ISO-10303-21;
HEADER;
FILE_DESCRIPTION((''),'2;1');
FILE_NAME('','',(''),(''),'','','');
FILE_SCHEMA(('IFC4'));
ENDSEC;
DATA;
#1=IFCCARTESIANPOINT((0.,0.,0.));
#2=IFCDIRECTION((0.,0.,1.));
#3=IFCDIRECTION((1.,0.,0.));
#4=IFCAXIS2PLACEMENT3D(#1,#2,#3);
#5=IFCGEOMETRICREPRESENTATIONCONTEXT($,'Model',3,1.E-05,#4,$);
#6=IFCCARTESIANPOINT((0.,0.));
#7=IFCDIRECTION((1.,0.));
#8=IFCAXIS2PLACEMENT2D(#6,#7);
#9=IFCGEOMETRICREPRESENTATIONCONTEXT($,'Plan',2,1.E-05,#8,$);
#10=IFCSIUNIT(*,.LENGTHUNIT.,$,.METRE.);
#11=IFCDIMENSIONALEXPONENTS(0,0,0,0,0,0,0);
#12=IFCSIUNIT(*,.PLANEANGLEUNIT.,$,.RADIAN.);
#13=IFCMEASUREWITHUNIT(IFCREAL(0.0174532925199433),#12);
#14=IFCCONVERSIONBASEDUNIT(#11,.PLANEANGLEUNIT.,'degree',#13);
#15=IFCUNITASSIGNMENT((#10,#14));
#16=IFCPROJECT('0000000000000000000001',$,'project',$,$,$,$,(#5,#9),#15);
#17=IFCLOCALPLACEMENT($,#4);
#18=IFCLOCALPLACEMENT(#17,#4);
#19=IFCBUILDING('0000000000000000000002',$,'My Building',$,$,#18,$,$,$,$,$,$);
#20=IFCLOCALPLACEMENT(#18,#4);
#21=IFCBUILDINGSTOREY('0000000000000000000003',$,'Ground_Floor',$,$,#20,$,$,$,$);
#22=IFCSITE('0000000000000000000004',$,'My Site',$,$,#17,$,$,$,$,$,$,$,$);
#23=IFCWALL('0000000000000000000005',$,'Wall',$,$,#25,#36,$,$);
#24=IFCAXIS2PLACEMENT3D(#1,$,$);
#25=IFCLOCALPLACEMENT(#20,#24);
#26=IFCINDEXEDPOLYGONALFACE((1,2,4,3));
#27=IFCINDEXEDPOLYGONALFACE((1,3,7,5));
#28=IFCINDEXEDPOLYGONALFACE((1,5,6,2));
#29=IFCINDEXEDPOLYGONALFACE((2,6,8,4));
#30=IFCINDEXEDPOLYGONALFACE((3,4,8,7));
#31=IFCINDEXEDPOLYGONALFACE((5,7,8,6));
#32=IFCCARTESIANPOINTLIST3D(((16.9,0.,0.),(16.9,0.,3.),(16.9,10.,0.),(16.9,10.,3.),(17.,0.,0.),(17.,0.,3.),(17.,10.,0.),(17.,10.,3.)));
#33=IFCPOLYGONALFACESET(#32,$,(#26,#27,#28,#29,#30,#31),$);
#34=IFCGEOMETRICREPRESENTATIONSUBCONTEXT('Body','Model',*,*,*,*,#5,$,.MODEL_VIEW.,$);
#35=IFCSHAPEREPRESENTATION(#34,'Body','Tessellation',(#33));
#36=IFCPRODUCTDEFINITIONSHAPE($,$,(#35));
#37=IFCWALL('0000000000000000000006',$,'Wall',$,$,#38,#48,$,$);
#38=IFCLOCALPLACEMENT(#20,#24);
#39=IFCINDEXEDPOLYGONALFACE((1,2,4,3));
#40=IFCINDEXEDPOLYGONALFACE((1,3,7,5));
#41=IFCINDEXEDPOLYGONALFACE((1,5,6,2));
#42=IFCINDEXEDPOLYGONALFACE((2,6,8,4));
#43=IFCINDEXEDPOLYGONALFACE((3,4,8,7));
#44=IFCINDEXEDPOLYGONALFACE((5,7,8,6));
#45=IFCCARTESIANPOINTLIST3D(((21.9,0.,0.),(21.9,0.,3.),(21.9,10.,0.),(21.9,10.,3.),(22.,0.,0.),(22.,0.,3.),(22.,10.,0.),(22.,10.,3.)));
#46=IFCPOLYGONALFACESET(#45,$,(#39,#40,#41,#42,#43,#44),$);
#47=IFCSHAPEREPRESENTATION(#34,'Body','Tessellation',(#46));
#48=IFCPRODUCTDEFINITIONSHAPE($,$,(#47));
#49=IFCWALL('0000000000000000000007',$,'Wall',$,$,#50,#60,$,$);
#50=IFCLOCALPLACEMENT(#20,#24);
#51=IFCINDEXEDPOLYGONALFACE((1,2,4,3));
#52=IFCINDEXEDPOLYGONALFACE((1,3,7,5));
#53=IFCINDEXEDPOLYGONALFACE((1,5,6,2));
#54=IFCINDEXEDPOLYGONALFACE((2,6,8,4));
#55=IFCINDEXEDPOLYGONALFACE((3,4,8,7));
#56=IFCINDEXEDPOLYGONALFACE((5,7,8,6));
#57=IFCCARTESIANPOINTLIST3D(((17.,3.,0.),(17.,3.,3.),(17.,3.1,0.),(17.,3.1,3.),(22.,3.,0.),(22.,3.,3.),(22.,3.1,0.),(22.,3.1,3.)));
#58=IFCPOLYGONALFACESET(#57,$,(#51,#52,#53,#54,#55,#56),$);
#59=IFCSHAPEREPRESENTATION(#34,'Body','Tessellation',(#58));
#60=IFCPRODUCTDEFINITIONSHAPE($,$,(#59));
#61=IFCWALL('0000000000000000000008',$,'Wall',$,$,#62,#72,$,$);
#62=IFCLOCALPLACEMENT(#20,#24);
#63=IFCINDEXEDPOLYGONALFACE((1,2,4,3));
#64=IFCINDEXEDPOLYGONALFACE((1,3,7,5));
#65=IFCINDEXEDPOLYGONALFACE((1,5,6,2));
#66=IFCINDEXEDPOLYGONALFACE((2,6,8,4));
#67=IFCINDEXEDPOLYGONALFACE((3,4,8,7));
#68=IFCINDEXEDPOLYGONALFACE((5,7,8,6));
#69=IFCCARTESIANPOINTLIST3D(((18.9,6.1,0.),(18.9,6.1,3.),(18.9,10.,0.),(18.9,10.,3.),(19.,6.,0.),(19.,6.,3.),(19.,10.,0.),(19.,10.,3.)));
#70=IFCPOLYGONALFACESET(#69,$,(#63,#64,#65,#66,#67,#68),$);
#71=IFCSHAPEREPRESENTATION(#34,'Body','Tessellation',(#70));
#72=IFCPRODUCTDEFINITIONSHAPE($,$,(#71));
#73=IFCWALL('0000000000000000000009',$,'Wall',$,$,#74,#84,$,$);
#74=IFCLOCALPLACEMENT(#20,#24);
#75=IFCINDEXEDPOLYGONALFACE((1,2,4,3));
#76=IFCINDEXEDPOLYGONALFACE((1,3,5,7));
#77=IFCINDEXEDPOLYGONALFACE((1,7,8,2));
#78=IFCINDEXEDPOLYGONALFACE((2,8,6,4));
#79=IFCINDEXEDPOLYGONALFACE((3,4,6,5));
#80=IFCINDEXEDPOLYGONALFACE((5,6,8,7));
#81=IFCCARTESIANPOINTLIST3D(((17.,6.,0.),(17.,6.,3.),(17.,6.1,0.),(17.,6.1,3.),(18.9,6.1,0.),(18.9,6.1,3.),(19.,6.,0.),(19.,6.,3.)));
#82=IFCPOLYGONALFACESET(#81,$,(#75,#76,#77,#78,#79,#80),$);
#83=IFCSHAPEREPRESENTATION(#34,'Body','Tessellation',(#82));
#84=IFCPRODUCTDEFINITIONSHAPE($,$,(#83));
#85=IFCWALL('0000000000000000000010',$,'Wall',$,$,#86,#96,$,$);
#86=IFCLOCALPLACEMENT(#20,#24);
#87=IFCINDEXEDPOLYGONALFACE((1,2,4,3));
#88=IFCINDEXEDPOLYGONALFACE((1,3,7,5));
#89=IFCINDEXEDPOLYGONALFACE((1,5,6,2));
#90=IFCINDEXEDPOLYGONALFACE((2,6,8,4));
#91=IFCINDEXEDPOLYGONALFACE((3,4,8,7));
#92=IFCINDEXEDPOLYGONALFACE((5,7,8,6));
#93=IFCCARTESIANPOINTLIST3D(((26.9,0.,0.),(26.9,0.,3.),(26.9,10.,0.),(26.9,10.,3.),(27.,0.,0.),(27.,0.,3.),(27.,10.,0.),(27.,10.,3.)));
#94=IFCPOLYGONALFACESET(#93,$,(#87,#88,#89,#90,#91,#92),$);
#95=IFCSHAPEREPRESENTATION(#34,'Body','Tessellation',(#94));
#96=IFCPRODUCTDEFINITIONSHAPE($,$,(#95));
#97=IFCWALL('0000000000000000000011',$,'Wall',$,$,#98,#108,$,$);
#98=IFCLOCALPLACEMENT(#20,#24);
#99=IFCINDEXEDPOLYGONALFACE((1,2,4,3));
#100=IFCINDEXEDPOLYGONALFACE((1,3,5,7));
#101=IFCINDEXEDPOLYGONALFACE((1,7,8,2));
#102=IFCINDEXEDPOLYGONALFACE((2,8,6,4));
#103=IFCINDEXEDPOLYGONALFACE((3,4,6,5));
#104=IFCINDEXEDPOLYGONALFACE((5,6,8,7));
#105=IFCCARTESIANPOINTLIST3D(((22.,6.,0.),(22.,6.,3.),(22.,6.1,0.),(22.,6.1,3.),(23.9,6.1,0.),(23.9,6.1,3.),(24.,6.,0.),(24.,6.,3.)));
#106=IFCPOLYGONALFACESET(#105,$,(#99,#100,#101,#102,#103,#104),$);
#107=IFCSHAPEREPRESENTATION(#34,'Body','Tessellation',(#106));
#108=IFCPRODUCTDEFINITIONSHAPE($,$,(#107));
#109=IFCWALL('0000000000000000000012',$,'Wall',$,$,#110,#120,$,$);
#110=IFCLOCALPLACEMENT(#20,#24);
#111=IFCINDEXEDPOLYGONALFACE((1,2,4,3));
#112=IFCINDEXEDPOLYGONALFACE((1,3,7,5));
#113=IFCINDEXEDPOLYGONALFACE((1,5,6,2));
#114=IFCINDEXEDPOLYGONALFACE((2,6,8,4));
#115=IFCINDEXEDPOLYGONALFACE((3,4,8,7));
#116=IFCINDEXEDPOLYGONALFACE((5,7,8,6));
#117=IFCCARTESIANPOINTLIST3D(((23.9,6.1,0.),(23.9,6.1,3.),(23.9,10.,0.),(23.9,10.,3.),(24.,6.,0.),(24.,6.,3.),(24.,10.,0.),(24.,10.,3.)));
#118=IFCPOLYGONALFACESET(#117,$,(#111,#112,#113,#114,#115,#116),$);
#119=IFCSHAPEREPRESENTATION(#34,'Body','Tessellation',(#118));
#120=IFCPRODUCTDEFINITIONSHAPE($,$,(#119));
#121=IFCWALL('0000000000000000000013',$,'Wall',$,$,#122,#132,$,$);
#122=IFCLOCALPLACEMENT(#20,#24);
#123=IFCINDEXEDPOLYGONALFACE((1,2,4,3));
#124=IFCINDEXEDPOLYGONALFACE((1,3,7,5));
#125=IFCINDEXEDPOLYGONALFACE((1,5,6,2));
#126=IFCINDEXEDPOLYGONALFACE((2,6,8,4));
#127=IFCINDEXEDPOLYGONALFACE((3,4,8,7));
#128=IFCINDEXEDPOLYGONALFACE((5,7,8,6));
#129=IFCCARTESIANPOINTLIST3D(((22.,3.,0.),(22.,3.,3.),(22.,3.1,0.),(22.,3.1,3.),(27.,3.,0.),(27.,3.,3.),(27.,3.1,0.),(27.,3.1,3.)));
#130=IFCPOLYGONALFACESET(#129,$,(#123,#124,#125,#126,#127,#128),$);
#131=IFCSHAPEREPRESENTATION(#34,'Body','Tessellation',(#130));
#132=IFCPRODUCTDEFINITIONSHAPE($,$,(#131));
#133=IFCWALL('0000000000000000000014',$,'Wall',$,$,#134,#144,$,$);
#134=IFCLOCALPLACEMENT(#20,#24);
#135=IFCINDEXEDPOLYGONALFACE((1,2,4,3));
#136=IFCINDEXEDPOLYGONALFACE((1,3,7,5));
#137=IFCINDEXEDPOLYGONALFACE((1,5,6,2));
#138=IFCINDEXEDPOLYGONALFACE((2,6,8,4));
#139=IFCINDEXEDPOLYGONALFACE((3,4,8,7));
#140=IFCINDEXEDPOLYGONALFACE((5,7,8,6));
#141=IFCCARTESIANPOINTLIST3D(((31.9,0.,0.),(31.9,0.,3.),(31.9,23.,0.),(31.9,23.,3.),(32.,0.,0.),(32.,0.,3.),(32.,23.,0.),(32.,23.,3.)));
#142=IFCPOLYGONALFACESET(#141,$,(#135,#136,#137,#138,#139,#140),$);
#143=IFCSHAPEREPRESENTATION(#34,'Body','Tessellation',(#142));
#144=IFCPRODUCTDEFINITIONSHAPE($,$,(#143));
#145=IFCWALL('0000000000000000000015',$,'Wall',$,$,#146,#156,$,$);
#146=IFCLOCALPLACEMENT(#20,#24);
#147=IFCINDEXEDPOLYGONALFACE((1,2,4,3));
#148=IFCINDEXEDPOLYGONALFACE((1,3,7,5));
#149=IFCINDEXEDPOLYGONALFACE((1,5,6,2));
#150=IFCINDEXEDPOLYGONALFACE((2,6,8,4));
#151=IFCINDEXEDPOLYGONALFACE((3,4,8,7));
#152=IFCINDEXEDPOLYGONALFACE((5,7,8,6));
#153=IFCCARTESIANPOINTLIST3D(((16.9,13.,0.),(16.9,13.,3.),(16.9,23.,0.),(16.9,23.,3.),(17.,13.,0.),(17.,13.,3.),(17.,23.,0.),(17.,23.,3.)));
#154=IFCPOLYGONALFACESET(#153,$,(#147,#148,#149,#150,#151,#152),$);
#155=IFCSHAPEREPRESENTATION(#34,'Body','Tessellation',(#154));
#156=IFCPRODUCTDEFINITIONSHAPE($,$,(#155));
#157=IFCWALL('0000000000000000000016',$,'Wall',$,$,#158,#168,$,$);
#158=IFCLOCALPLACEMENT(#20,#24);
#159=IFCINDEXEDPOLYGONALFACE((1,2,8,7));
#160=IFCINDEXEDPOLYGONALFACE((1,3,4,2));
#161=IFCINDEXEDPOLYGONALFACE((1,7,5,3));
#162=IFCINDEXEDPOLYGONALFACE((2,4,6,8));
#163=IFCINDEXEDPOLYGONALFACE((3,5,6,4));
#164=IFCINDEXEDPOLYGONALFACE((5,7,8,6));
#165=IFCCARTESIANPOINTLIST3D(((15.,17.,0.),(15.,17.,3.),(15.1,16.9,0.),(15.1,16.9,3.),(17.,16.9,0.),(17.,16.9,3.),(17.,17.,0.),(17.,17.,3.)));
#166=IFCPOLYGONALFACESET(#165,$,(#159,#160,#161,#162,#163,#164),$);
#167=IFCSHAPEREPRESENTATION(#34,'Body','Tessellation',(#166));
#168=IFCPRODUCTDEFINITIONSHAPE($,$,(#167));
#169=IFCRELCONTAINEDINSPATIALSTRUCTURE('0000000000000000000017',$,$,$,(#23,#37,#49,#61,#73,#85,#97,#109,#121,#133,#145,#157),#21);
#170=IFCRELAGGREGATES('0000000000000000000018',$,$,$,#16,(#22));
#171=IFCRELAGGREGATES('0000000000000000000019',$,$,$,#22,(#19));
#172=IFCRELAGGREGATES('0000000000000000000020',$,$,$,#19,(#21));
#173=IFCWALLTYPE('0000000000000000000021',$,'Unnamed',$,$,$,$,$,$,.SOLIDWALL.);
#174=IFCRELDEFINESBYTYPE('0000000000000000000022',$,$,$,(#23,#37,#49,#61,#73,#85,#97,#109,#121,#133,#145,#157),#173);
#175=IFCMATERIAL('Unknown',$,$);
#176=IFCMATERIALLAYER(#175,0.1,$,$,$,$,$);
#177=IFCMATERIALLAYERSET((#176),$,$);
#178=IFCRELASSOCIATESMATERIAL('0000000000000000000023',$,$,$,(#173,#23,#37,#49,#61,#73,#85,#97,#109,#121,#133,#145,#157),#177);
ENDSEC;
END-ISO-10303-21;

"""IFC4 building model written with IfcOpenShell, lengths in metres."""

from ifc_helpers import new_model, entity, si_unit, converted_unit, frame, origin_with_axes, origin_2d_with_axis, place, context, subcontext, project, spatial, line, indexed_curve, outline, extrude, material, layer, layer_set, layer_usage, type_object, element, save


model = new_model("IFC4")

# Units and contexts
model_context = context("Model", 3, precision=1e-05, world=origin_with_axes())
plan_context = context("Plan", 2, precision=1e-05, world=origin_2d_with_axis())
body_context_1 = subcontext(model_context, "Body", "Model", "MODEL_VIEW")
ifc_project = project(units=[si_unit("LENGTHUNIT", "METRE"), converted_unit("PLANEANGLEUNIT", "degree", entity("IfcReal", 0.0174532925199433), si_unit("PLANEANGLEUNIT", "RADIAN"), dimensions=[0, 0, 0, 0, 0, 0, 0])], contexts=[model_context, plan_context])

# Site, building, storey
site_placement = place(None, origin_with_axes())
site = spatial("IfcSite", under=ifc_project, at=site_placement, Name="My Site")
building_placement = place(site_placement, origin_with_axes())
building = spatial("IfcBuilding", under=site, at=building_placement, Name="My Building")
storey_placement = place(building_placement, origin_with_axes())
storey = spatial("IfcBuildingStorey", under=building, at=storey_placement, Name="Ground_Floor")

# Walls
ifc_material = material(Name="Unknown")
ifc_layer = layer(ifc_material, 0.1)
ifc_layer_set = layer_set([ifc_layer])
ifc_layer_usage_1 = layer_usage(ifc_layer_set, "AXIS2", "POSITIVE", 0.0)
wall_type = type_object("IfcWallType", Name="Unnamed", PredefinedType="SOLIDWALL", material=ifc_layer_set)
wall_1_placement = place(storey_placement, frame((17.0, 0.0, 0.0), z_axis=(0.0, 0.0, 1.0), x_axis=(0.0, 1.0, 0.0)))
element("IfcWall", 1, at=wall_1_placement, inside=storey, type_object=wall_type, material=ifc_layer_usage_1, Name="Wall", context=body_context_1, shape_type="SweptSolid", body=[
    extrude(outline(indexed_curve([(0.0, 0.0), (0.0, 0.1), (10.0, 0.1), (10.0, 0.0)], segments=[line(1, 2, 3, 4, 1)])), origin_with_axes(), (0.0, 0.0, 1.0), 3.0),
])
ifc_layer_usage_2 = layer_usage(ifc_layer_set, "AXIS2", "POSITIVE", 0.0)
wall_2_placement = place(storey_placement, frame((22.0, 0.0, 0.0), z_axis=(0.0, 0.0, 1.0), x_axis=(0.0, 1.0, 0.0)))
element("IfcWall", 2, at=wall_2_placement, inside=storey, type_object=wall_type, material=ifc_layer_usage_2, Name="Wall", context=body_context_1, shape_type="SweptSolid", body=[
    extrude(outline(indexed_curve([(0.0, 0.0), (0.0, 0.1), (10.0, 0.1), (10.0, 0.0)], segments=[line(1, 2, 3, 4, 1)])), origin_with_axes(), (0.0, 0.0, 1.0), 3.0),
])
ifc_layer_usage_3 = layer_usage(ifc_layer_set, "AXIS2", "POSITIVE", 0.0)
wall_3_placement = place(storey_placement, frame((17.0, 3.0, 0.0), z_axis=(0.0, 0.0, 1.0), x_axis=(1.0, 0.0, 0.0)))
element("IfcWall", 3, at=wall_3_placement, inside=storey, type_object=wall_type, material=ifc_layer_usage_3, Name="Wall", context=body_context_1, shape_type="SweptSolid", body=[
    extrude(outline(indexed_curve([(0.0, 0.0), (0.0, 0.1), (5.0, 0.1), (5.0, 0.0)], segments=[line(1, 2, 3, 4, 1)])), origin_with_axes(), (0.0, 0.0, 1.0), 3.0),
])
ifc_layer_usage_4 = layer_usage(ifc_layer_set, "AXIS2", "POSITIVE", 0.0)
wall_4_placement = place(storey_placement, frame((19.0, 6.0, 0.0), z_axis=(0.0, 0.0, 1.0), x_axis=(0.0, 1.0, 0.0)))
element("IfcWall", 4, at=wall_4_placement, inside=storey, type_object=wall_type, material=ifc_layer_usage_4, Name="Wall", context=body_context_1, shape_type="SweptSolid", body=[
    extrude(outline(indexed_curve([(0.0, 0.0), (0.1, 0.1), (4.0, 0.1), (4.0, 0.0)], segments=[line(1, 2, 3, 4, 1)])), origin_with_axes(), (0.0, 0.0, 1.0), 3.0),
])
ifc_layer_usage_5 = layer_usage(ifc_layer_set, "AXIS2", "POSITIVE", 0.0)
wall_5_placement = place(storey_placement, frame((17.0, 6.0, 0.0), z_axis=(0.0, 0.0, 1.0), x_axis=(1.0, 0.0, 0.0)))
element("IfcWall", 5, at=wall_5_placement, inside=storey, type_object=wall_type, material=ifc_layer_usage_5, Name="Wall", context=body_context_1, shape_type="SweptSolid", body=[
    extrude(outline(indexed_curve([(0.0, 0.0), (0.0, 0.1), (1.9, 0.1), (2.0, 0.0)], segments=[line(1, 2, 3, 4, 1)])), origin_with_axes(), (0.0, 0.0, 1.0), 3.0),
])
ifc_layer_usage_6 = layer_usage(ifc_layer_set, "AXIS2", "POSITIVE", 0.0)
wall_6_placement = place(storey_placement, frame((27.0, 0.0, 0.0), z_axis=(0.0, 0.0, 1.0), x_axis=(0.0, 1.0, 0.0)))
element("IfcWall", 6, at=wall_6_placement, inside=storey, type_object=wall_type, material=ifc_layer_usage_6, Name="Wall", context=body_context_1, shape_type="SweptSolid", body=[
    extrude(outline(indexed_curve([(0.0, 0.0), (0.0, 0.1), (10.0, 0.1), (10.0, 0.0)], segments=[line(1, 2, 3, 4, 1)])), origin_with_axes(), (0.0, 0.0, 1.0), 3.0),
])
ifc_layer_usage_7 = layer_usage(ifc_layer_set, "AXIS2", "POSITIVE", 0.0)
wall_7_placement = place(storey_placement, frame((22.0, 6.0, 0.0), z_axis=(0.0, 0.0, 1.0), x_axis=(1.0, 0.0, 0.0)))
element("IfcWall", 7, at=wall_7_placement, inside=storey, type_object=wall_type, material=ifc_layer_usage_7, Name="Wall", context=body_context_1, shape_type="SweptSolid", body=[
    extrude(outline(indexed_curve([(0.0, 0.0), (0.0, 0.1), (1.9, 0.1), (2.0, 0.0)], segments=[line(1, 2, 3, 4, 1)])), origin_with_axes(), (0.0, 0.0, 1.0), 3.0),
])
ifc_layer_usage_8 = layer_usage(ifc_layer_set, "AXIS2", "POSITIVE", 0.0)
wall_8_placement = place(storey_placement, frame((24.0, 6.0, 0.0), z_axis=(0.0, 0.0, 1.0), x_axis=(0.0, 1.0, 0.0)))
element("IfcWall", 8, at=wall_8_placement, inside=storey, type_object=wall_type, material=ifc_layer_usage_8, Name="Wall", context=body_context_1, shape_type="SweptSolid", body=[
    extrude(outline(indexed_curve([(0.0, 0.0), (0.1, 0.1), (4.0, 0.1), (4.0, 0.0)], segments=[line(1, 2, 3, 4, 1)])), origin_with_axes(), (0.0, 0.0, 1.0), 3.0),
])
ifc_layer_usage_9 = layer_usage(ifc_layer_set, "AXIS2", "POSITIVE", 0.0)
wall_9_placement = place(storey_placement, frame((22.0, 3.0, 0.0), z_axis=(0.0, 0.0, 1.0), x_axis=(1.0, 0.0, 0.0)))
element("IfcWall", 9, at=wall_9_placement, inside=storey, type_object=wall_type, material=ifc_layer_usage_9, Name="Wall", context=body_context_1, shape_type="SweptSolid", body=[
    extrude(outline(indexed_curve([(0.0, 0.0), (0.0, 0.1), (5.0, 0.1), (5.0, 0.0)], segments=[line(1, 2, 3, 4, 1)])), origin_with_axes(), (0.0, 0.0, 1.0), 3.0),
])
ifc_layer_usage_10 = layer_usage(ifc_layer_set, "AXIS2", "POSITIVE", 0.0)
wall_10_placement = place(storey_placement, frame((32.0, 0.0, 0.0), z_axis=(0.0, 0.0, 1.0), x_axis=(0.0, 1.0, 0.0)))
element("IfcWall", 10, at=wall_10_placement, inside=storey, type_object=wall_type, material=ifc_layer_usage_10, Name="Wall", context=body_context_1, shape_type="SweptSolid", body=[
    extrude(outline(indexed_curve([(0.0, 0.0), (0.0, 0.1), (23.0, 0.1), (23.0, 0.0)], segments=[line(1, 2, 3, 4, 1)])), origin_with_axes(), (0.0, 0.0, 1.0), 3.0),
])
ifc_layer_usage_11 = layer_usage(ifc_layer_set, "AXIS2", "POSITIVE", 0.0)
wall_11_placement = place(storey_placement, frame((17.0, 13.0, 0.0), z_axis=(0.0, 0.0, 1.0), x_axis=(0.0, 1.0, 0.0)))
element("IfcWall", 11, at=wall_11_placement, inside=storey, type_object=wall_type, material=ifc_layer_usage_11, Name="Wall", context=body_context_1, shape_type="SweptSolid", body=[
    extrude(outline(indexed_curve([(0.0, 0.0), (0.0, 0.1), (10.0, 0.1), (10.0, 0.0)], segments=[line(1, 2, 3, 4, 1)])), origin_with_axes(), (0.0, 0.0, 1.0), 3.0),
])
ifc_layer_usage_12 = layer_usage(ifc_layer_set, "AXIS2", "POSITIVE", 0.0)
wall_12_placement = place(storey_placement, frame((17.0, 17.0, 0.0), z_axis=(0.0, 0.0, 1.0), x_axis=(-1.0, 0.0, 0.0)))
element("IfcWall", 12, at=wall_12_placement, inside=storey, type_object=wall_type, material=ifc_layer_usage_12, Name="Wall", context=body_context_1, shape_type="SweptSolid", body=[
    extrude(outline(indexed_curve([(0.0, 0.0), (0.0, 0.1), (1.9, 0.1), (2.0, 0.0)], segments=[line(1, 2, 3, 4, 1)])), origin_with_axes(), (0.0, 0.0, 1.0), 3.0),
])

save(model, "model.ifc")
